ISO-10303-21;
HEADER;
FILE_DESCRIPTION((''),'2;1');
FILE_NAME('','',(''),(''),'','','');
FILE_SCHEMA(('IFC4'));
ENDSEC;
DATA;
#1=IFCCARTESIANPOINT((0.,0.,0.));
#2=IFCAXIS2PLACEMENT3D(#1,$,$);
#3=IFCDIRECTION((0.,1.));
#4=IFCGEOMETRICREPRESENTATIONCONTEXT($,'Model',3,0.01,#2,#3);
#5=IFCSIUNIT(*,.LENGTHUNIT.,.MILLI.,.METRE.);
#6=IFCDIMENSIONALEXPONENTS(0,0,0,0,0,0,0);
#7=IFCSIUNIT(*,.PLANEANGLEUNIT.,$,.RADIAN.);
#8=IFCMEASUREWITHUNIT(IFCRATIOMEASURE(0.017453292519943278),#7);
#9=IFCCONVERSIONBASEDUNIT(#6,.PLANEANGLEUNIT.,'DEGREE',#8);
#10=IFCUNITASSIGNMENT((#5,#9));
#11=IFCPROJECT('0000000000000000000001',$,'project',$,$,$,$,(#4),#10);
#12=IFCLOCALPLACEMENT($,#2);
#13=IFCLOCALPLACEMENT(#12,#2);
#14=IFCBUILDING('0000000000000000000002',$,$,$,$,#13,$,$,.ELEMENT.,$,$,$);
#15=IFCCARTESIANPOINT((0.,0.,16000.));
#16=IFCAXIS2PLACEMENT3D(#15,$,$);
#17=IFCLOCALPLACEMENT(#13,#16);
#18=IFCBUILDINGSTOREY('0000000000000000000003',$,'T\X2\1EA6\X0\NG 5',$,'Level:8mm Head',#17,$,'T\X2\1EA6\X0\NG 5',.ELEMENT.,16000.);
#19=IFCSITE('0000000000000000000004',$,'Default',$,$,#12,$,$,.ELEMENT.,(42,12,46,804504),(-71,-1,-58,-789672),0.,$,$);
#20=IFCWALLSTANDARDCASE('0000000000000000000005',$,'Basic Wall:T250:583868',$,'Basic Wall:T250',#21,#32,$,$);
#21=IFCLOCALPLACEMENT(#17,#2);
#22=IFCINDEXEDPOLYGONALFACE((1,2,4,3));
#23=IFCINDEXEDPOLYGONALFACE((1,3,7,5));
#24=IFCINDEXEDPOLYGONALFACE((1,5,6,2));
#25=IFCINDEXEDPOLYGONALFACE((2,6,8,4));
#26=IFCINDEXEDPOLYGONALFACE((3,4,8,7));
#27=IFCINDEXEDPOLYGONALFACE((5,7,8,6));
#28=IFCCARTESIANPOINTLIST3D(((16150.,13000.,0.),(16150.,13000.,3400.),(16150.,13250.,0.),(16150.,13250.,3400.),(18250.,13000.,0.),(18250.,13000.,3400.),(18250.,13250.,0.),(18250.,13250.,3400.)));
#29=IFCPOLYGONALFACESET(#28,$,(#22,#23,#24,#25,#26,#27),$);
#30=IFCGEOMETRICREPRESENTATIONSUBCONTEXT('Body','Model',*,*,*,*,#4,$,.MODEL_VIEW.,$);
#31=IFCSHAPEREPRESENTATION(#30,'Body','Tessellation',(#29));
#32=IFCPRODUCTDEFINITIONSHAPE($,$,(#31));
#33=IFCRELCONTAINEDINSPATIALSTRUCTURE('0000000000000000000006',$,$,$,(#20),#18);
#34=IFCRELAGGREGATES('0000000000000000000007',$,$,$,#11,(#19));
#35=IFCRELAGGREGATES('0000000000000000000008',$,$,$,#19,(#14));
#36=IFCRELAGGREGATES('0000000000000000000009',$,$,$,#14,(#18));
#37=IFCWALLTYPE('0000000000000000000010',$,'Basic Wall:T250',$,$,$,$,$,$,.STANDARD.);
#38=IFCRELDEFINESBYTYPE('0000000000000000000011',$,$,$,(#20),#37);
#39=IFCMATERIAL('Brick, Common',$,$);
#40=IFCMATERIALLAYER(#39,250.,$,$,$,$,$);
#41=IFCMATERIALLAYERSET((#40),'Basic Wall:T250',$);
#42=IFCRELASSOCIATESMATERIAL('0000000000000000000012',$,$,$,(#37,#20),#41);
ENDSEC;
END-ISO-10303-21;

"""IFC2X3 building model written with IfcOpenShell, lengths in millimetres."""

from ifc_helpers import new_model, entity, si_unit, converted_unit, direction, frame, frame_2d, origin, place, context, subcontext, project, spatial, rectangle, extrude, material, layer, layer_set, layer_usage, type_object, element, save


model = new_model("IFC2X3")

# Units and contexts
model_context = context("Model", 3, precision=0.01, world=origin(), true_north=direction((0.0, 1.0)))
body_context = subcontext(model_context, "Body", "Model", "MODEL_VIEW")
ifc_project = project(units=[si_unit("LENGTHUNIT", "METRE", prefix="MILLI"), converted_unit("PLANEANGLEUNIT", "DEGREE", entity("IfcRatioMeasure", 0.017453292519943278), si_unit("PLANEANGLEUNIT", "RADIAN"), dimensions=[0, 0, 0, 0, 0, 0, 0])], contexts=[model_context])

# Site, building, storey
site_placement = place(None, origin())
site = spatial("IfcSite", under=ifc_project, at=site_placement, Name="Default", CompositionType="ELEMENT", RefLatitude=(42, 12, 46, 804504), RefLongitude=(-71, -1, -58, -789672), RefElevation=0.0)
building_placement = place(site_placement, origin())
building = spatial("IfcBuilding", under=site, at=building_placement, CompositionType="ELEMENT")
storey_placement = place(building_placement, frame((0.0, 0.0, 16000.0)))
storey = spatial("IfcBuildingStorey", under=building, at=storey_placement, Name="TẦNG 5", ObjectType="Level:8mm Head", LongName="TẦNG 5", CompositionType="ELEMENT", Elevation=16000.0)

# Shared definitions
ifc_material_1 = material(Name="Brick, Common")

# Wall
ifc_layer_1 = layer(ifc_material_1, 250.0)
ifc_layer_set_1 = layer_set([ifc_layer_1], Name="Basic Wall:T250")
ifc_layer_usage_1 = layer_usage(ifc_layer_set_1, "AXIS2", "POSITIVE", -125.0)
wall_type_1 = type_object("IfcWallType", Name="Basic Wall:T250", PredefinedType="STANDARD", material=ifc_layer_set_1)
wall_1_placement = place(storey_placement, frame((16150.0, 13125.0, 0.0)))
element("IfcWallStandardCase", 1, at=wall_1_placement, inside=storey, type_object=wall_type_1, material=ifc_layer_usage_1, Name="Basic Wall:T250:583868", ObjectType="Basic Wall:T250", context=body_context, shape_type="SweptSolid", body=[
    extrude(rectangle(XDim=2100.0, YDim=250.0, at=frame_2d((1050.0, 0.0), x_axis=(-1.0, 0.0))), origin(), (0.0, 0.0, 1.0), 3400.0),
])

save(model, "model.ifc")
